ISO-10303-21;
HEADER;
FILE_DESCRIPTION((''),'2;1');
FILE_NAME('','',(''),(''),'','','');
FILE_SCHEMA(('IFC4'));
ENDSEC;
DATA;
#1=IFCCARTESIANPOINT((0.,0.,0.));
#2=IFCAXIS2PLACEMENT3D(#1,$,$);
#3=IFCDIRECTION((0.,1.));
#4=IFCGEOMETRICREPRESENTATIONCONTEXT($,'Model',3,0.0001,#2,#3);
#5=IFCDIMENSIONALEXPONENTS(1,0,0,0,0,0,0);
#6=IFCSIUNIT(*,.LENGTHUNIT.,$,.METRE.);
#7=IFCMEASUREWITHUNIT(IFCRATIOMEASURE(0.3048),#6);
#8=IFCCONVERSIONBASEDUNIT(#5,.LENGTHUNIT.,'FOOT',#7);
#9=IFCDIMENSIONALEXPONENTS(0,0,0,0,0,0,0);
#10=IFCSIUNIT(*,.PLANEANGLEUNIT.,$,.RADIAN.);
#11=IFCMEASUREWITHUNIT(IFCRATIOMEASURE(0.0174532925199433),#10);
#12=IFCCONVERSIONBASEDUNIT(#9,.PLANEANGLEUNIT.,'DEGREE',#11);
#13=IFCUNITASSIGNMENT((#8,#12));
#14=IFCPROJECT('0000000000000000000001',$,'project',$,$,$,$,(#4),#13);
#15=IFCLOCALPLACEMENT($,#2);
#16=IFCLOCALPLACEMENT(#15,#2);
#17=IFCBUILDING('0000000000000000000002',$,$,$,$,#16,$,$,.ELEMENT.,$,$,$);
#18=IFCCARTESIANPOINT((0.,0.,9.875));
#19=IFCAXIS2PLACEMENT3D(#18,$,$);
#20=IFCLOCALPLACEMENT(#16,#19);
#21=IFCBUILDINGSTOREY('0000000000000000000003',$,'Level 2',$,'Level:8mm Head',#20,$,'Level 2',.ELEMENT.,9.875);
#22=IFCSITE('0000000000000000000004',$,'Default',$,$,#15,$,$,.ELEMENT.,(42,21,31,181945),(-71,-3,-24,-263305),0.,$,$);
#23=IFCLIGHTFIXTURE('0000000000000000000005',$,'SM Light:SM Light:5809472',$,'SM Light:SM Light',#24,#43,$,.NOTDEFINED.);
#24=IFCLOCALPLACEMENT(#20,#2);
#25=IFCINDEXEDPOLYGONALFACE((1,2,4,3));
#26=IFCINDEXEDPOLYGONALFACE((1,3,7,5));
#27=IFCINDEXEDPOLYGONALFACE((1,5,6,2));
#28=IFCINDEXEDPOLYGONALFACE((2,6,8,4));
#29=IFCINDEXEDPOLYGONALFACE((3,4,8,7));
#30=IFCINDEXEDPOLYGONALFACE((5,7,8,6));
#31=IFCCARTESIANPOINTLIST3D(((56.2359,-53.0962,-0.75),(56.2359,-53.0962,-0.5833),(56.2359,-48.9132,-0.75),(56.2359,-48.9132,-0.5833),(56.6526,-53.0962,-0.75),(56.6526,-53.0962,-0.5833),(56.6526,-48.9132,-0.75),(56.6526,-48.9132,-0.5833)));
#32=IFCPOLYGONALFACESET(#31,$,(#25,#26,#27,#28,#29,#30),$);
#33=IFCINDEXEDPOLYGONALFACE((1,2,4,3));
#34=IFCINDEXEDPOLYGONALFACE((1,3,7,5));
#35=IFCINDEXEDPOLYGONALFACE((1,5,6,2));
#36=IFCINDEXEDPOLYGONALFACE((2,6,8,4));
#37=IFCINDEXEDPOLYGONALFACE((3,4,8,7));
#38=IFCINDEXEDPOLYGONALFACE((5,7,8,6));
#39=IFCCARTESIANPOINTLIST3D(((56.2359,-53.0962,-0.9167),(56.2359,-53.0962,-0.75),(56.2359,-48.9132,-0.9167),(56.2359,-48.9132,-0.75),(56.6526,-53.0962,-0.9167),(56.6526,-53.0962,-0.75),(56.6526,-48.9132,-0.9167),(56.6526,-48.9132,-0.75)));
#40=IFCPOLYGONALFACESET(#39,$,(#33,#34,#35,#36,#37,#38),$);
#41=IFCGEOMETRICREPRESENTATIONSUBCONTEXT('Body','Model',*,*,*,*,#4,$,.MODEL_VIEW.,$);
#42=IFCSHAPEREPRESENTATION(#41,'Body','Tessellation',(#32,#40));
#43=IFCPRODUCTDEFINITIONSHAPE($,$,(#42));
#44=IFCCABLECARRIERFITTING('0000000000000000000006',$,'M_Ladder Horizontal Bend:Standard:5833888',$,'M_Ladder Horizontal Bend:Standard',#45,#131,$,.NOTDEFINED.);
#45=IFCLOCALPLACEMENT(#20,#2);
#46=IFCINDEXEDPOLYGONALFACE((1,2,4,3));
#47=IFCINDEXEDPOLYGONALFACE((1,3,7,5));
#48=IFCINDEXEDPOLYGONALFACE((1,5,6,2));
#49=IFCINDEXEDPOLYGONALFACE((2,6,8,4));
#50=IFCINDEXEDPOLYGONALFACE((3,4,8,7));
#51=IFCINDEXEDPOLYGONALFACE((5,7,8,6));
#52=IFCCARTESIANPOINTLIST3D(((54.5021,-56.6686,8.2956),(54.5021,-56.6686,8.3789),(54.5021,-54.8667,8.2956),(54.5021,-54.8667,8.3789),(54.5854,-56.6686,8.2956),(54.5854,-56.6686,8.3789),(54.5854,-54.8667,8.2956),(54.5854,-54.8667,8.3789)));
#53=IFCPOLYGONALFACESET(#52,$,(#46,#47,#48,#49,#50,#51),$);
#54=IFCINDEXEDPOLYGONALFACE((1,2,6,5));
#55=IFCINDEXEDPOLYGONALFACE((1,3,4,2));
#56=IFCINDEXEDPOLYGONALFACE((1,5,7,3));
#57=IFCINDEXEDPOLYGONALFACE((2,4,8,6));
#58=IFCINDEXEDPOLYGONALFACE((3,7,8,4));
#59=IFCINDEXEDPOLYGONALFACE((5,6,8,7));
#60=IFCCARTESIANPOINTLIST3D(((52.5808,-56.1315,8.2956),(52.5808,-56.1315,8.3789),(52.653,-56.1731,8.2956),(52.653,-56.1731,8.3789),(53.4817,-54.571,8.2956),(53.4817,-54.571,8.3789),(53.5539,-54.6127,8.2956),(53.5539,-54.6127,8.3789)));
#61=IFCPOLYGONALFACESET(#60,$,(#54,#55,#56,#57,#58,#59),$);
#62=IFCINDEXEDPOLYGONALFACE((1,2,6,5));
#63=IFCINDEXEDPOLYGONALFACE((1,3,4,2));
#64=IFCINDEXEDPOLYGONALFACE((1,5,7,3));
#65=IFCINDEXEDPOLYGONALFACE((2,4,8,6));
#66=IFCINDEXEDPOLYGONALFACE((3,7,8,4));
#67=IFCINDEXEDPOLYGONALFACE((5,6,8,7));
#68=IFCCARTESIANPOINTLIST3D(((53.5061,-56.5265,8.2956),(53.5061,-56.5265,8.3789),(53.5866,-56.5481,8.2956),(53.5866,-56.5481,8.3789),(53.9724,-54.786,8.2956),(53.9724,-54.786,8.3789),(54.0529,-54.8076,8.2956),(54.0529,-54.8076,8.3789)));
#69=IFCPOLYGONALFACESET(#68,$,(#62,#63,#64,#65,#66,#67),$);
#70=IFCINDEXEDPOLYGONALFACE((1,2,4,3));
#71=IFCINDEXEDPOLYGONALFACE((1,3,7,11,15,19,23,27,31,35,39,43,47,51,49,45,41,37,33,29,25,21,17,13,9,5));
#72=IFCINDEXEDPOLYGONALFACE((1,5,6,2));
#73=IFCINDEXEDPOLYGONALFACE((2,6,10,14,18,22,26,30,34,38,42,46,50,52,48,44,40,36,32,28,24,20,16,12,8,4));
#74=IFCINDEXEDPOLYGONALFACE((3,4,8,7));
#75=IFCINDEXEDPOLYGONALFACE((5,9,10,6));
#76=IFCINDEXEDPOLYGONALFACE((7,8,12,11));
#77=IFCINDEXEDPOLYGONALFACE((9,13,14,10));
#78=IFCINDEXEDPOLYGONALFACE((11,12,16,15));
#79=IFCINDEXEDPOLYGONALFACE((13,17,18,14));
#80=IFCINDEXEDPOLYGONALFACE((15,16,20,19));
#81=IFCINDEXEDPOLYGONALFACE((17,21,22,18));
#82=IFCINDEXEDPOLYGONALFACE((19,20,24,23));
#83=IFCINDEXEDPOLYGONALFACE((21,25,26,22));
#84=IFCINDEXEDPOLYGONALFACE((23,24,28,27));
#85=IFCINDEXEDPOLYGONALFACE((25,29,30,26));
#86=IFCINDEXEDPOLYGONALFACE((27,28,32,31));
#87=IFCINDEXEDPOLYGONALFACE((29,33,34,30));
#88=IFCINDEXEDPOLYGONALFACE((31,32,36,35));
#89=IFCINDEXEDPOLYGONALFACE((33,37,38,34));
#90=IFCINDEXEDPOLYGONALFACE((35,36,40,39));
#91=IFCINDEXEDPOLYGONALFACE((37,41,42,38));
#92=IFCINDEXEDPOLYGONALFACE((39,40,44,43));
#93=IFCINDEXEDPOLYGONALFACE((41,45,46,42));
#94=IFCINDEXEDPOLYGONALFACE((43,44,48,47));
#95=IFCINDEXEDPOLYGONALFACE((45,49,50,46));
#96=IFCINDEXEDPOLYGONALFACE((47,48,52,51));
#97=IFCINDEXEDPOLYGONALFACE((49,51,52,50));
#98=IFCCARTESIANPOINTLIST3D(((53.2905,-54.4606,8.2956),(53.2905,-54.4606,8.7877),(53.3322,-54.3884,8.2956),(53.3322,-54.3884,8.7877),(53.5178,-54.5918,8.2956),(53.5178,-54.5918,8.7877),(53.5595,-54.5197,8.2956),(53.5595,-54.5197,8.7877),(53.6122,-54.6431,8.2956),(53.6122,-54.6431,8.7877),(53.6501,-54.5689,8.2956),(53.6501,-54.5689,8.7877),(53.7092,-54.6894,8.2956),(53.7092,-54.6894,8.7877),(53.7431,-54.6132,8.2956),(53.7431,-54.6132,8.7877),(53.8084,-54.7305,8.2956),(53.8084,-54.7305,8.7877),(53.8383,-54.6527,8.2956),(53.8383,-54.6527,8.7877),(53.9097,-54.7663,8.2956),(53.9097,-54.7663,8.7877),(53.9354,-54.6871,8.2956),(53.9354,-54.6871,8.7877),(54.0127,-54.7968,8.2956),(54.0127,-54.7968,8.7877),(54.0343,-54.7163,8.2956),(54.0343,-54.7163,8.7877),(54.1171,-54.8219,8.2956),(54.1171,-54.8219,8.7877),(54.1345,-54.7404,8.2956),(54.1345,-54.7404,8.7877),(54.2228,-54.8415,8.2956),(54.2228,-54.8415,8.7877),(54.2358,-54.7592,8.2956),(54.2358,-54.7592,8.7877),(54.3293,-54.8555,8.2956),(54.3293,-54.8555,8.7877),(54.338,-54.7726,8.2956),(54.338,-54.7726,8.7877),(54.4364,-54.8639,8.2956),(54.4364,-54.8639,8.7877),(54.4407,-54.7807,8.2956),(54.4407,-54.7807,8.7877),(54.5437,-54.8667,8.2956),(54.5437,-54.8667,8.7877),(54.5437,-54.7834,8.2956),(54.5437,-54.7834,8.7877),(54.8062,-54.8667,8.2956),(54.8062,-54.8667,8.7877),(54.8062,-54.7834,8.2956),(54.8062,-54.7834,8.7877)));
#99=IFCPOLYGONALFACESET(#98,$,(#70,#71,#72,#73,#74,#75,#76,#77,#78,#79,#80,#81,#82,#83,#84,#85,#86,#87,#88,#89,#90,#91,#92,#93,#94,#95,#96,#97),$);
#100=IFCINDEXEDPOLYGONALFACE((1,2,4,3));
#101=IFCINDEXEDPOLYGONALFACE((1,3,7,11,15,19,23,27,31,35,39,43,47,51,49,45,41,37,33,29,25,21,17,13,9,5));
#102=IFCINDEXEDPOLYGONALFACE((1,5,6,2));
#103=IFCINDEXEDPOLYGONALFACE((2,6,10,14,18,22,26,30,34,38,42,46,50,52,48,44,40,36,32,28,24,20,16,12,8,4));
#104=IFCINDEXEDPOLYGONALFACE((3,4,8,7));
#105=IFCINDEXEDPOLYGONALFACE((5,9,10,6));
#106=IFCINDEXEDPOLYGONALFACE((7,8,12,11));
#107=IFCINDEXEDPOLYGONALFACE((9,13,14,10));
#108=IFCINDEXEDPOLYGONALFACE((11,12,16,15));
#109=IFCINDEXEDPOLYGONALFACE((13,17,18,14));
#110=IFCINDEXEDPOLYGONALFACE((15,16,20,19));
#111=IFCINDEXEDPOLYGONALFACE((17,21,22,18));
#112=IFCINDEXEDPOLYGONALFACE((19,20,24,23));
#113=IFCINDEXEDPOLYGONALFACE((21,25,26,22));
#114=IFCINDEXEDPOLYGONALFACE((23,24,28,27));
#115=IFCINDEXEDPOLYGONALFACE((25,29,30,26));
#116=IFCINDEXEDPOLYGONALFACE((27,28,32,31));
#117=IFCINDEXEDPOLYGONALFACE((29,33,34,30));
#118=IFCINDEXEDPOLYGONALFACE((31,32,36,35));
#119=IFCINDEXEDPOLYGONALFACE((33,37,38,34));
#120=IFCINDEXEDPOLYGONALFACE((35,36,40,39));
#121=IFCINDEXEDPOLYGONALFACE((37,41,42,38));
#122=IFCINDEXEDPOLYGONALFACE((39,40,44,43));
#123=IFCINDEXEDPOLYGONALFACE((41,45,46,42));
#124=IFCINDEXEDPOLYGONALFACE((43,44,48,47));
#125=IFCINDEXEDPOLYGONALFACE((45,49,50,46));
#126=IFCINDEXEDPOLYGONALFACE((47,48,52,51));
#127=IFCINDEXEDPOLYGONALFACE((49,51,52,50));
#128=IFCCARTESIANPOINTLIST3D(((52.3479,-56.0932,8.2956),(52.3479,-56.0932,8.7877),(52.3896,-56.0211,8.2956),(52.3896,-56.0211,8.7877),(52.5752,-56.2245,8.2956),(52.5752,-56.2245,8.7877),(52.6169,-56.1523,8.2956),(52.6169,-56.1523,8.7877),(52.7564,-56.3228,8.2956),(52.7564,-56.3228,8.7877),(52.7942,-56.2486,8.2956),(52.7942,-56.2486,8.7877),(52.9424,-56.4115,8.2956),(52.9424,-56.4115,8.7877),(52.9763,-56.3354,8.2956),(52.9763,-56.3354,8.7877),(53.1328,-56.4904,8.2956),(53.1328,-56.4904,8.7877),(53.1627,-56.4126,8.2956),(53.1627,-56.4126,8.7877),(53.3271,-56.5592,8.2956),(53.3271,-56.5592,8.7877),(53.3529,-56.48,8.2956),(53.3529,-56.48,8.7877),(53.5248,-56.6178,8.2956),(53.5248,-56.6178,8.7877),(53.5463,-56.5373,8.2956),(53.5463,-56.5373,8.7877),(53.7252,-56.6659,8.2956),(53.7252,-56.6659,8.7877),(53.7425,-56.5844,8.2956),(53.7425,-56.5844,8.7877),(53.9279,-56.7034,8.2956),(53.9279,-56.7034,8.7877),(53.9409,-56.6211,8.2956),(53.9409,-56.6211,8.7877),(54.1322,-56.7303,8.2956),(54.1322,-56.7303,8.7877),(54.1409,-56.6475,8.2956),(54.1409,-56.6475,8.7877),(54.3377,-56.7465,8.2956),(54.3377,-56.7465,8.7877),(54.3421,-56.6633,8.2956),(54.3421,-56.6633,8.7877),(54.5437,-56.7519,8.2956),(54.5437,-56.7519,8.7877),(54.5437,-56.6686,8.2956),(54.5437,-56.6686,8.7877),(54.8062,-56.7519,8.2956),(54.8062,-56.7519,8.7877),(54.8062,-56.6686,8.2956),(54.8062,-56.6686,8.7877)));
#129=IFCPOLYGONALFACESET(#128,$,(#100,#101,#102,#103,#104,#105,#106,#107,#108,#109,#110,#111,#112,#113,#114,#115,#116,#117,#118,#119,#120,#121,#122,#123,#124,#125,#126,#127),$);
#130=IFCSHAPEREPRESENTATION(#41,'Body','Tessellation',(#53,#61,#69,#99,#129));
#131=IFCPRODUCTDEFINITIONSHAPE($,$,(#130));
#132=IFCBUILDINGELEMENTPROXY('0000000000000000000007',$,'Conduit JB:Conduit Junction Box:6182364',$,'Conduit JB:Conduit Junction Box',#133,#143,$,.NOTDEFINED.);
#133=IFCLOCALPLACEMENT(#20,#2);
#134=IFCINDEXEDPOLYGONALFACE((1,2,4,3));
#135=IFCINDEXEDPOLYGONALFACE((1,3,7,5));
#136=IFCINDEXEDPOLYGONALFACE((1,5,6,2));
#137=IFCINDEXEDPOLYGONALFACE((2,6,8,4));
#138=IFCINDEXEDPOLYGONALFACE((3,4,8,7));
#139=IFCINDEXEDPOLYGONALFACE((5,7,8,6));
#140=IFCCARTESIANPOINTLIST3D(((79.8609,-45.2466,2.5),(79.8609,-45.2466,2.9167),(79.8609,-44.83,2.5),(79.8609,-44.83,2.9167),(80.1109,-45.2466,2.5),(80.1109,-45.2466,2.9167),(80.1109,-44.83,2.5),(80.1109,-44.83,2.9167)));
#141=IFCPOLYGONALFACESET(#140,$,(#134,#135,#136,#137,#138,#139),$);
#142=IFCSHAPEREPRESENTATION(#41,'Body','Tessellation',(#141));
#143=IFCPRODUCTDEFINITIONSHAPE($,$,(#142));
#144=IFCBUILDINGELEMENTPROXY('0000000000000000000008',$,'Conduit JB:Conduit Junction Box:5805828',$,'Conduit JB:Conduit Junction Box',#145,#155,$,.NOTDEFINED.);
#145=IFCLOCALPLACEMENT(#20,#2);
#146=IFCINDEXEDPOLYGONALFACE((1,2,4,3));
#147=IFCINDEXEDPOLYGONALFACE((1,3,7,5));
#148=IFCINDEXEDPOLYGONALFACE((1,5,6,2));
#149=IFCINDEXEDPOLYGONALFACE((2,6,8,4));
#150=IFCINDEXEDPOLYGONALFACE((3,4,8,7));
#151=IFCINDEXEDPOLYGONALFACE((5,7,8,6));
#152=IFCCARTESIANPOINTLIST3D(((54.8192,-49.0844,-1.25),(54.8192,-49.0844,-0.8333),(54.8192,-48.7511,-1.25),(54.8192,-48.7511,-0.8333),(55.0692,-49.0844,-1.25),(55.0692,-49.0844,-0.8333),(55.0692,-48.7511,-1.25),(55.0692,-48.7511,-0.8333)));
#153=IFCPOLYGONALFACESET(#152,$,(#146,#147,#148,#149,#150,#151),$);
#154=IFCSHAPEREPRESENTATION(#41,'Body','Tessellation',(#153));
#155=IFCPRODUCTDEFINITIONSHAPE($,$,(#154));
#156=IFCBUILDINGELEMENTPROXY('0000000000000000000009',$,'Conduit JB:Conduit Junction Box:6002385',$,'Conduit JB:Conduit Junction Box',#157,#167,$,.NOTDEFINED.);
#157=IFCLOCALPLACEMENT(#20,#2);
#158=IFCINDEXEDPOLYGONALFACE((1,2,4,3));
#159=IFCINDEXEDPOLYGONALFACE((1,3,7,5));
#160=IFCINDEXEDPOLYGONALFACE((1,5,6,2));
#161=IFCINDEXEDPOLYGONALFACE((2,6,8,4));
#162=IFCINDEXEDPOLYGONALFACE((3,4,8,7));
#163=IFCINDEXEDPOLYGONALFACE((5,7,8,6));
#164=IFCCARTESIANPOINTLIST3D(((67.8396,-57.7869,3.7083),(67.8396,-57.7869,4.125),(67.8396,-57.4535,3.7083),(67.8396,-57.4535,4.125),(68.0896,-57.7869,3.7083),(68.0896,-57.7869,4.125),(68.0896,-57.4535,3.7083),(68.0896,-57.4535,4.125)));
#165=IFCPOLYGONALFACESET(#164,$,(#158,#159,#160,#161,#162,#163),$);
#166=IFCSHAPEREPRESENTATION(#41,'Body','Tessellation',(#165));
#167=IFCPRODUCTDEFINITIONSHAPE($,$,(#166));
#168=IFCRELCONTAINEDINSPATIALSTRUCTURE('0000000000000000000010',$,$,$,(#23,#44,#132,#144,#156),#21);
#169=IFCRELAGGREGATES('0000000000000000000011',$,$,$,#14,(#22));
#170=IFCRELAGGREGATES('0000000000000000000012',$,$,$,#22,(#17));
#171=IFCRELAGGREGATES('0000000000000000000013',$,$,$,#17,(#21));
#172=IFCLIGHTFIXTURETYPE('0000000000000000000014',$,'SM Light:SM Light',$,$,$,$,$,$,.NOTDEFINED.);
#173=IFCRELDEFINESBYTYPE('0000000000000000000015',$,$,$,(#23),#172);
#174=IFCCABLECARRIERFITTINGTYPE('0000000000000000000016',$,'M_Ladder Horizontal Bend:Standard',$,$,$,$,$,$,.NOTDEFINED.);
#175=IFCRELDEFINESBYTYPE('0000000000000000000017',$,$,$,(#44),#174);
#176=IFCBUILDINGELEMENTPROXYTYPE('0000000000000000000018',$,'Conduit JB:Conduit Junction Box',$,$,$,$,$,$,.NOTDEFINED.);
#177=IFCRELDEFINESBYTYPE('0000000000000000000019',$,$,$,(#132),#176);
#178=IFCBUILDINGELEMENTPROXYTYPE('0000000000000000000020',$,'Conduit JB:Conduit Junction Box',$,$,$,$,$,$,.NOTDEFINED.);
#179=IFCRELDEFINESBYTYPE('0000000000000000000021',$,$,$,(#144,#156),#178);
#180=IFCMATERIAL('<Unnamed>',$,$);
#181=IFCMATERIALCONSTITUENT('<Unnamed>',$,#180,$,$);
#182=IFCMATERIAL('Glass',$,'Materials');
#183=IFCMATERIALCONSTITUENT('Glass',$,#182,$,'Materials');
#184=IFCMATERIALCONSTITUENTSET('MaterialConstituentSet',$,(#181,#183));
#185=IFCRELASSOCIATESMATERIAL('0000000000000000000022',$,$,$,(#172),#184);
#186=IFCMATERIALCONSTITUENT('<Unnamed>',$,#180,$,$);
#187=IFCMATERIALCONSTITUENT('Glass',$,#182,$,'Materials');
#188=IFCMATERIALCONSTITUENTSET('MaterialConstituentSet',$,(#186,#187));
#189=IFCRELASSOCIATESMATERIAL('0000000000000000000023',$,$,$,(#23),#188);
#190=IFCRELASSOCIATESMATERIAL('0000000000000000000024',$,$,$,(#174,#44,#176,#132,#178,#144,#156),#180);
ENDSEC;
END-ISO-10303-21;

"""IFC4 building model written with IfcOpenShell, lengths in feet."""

from ifc_helpers import new_model, entity, si_unit, converted_unit, direction, frame, origin, place, context, subcontext, project, spatial, indexed_curve, outline, extrude, source, transform, mapped, material, constituent, constituent_set, type_object, type_shapes, element, save


model = new_model("IFC4")

# Units and contexts
model_context = context("Model", 3, precision=0.0001, world=origin(), true_north=direction((0.0, 1.0)))
body_context = subcontext(model_context, "Body", "Model", "MODEL_VIEW")
ifc_project = project(units=[converted_unit("LENGTHUNIT", "FOOT", entity("IfcRatioMeasure", 0.3048), si_unit("LENGTHUNIT", "METRE"), dimensions=[1, 0, 0, 0, 0, 0, 0]), converted_unit("PLANEANGLEUNIT", "DEGREE", entity("IfcRatioMeasure", 0.0174532925199433), si_unit("PLANEANGLEUNIT", "RADIAN"), dimensions=[0, 0, 0, 0, 0, 0, 0])], contexts=[model_context])

# Site, building, storey
site_placement = place(None, origin())
site = spatial("IfcSite", under=ifc_project, at=site_placement, Name="Default", CompositionType="ELEMENT", RefLatitude=(42, 21, 31, 181945), RefLongitude=(-71, -3, -24, -263305), RefElevation=0.0)
building_placement = place(site_placement, origin())
building = spatial("IfcBuilding", under=site, at=building_placement, CompositionType="ELEMENT")
storey_placement = place(building_placement, frame((0.0, 0.0, 9.875)))
storey = spatial("IfcBuildingStorey", under=building, at=storey_placement, Name="Level 2", ObjectType="Level:8mm Head", LongName="Level 2", CompositionType="ELEMENT", Elevation=9.875)

# Light fixture
ifc_material_1 = material(Name="<Unnamed>")
ifc_material_2 = material(Name="Glass", Category="Materials")
ifc_constituent_1 = constituent(ifc_material_1, Name="<Unnamed>")
ifc_constituent_2 = constituent(ifc_material_2, Name="Glass", Category="Materials")
ifc_constituent_set_1 = constituent_set(constituents=[ifc_constituent_1, ifc_constituent_2], Name="MaterialConstituentSet")
light_fixture_type = type_object("IfcLightFixtureType", Name="SM Light:SM Light", PredefinedType="NOTDEFINED", material=ifc_constituent_set_1)
shared_shape_1 = source(origin(), body_context, "Body", "SweptSolid", [
    extrude(outline(indexed_curve([(-0.2083, -2.0915), (0.2083, -2.0915), (0.2083, 2.0915), (-0.2083, 2.0915), (-0.2083, -2.0915)], self_intersect=False)), frame((-0.0016, -0.2083, 0.1667), z_axis=(0.0, 0.0, 1.0), x_axis=(0.0, 1.0, 0.0)), (0.0, 0.0, 1.0), 0.1667),
    extrude(outline(indexed_curve([(-0.2083, -2.0915), (0.2083, -2.0915), (0.2083, 2.0915), (-0.2083, 2.0915), (-0.2083, -2.0915)], self_intersect=False)), frame((-0.0016, -0.2083, 0.0), z_axis=(0.0, 0.0, 1.0), x_axis=(0.0, 1.0, 0.0)), (0.0, 0.0, 1.0), 0.1667),
])
type_shapes(light_fixture_type, [shared_shape_1])
ifc_constituent_3 = constituent(ifc_material_1, Name="<Unnamed>")
ifc_constituent_4 = constituent(ifc_material_2, Name="Glass", Category="Materials")
ifc_constituent_set_2 = constituent_set(constituents=[ifc_constituent_3, ifc_constituent_4], Name="MaterialConstituentSet")
light_fixture_1_placement = place(storey_placement, frame((56.2359, -51.0031, -0.9167), z_axis=(0.0, 0.0, 1.0), x_axis=(0.0, 1.0, 0.0)))
element("IfcLightFixture", 1, at=light_fixture_1_placement, inside=storey, type_object=light_fixture_type, material=ifc_constituent_set_2, Name="SM Light:SM Light:5809472", ObjectType="SM Light:SM Light", PredefinedType="NOTDEFINED", context=body_context, shape_type="MappedRepresentation", body=[
    mapped(shared_shape_1, transform((0.0, 0.0, 0.0), scale=1.0)),
])

# Cable carrier fitting
cable_carrier_fitting_type_1 = type_object("IfcCableCarrierFittingType", Name="M_Ladder Horizontal Bend:Standard", PredefinedType="NOTDEFINED", material=ifc_material_1)
shared_shape_2 = source(origin(), body_context, "Body", "SweptSolid", [
    extrude(outline(indexed_curve([(-0.9009, -0.0417), (0.9009, -0.0417), (0.9009, 0.0417), (-0.9009, 0.0417), (-0.9009, -0.0417)], self_intersect=False)), frame((0.6852, 0.3956, -0.2461), z_axis=(0.0, 0.0, 1.0), x_axis=(0.5, -0.866025, 0.0)), (0.0, 0.0, 1.0), 0.0833),
    extrude(outline(indexed_curve([(-0.9009, -0.0417), (0.9009, -0.0417), (0.9009, 0.0417), (-0.9009, 0.0417), (-0.9009, -0.0417)], self_intersect=False)), frame((-0.7912, 0.0, -0.2461), z_axis=(0.0, 0.0, 1.0), x_axis=(0.0, -1.0, 0.0)), (0.0, 0.0, 1.0), 0.0833),
    extrude(outline(indexed_curve([(-0.9009, -0.0417), (0.9009, -0.0417), (0.9009, 0.0417), (-0.9009, 0.0417), (-0.9009, -0.0417)], self_intersect=False)), frame((-0.027, 0.1006, -0.2461), z_axis=(0.0, 0.0, 1.0), x_axis=(0.258819, -0.965926, 0.0)), (0.0, 0.0, 1.0), 0.0833),
    extrude(outline(indexed_curve([(-0.7562, -0.2091), (-0.4938, -0.2091), (-0.3864, -0.2063), (-0.2793, -0.1979), (-0.1728, -0.1839), (-0.0672, -0.1643), (0.0373, -0.1392), (0.1403, -0.1087), (0.2416, -0.0728), (0.3408, -0.0317), (0.4378, 0.0145), (0.5322, 0.0658), (0.7595, 0.197), (0.7178, 0.2692), (0.4905, 0.1379), (0.3999, 0.0888), (0.3069, 0.0444), (0.2117, 0.0049), (0.1145, -0.0295), (0.0157, -0.0587), (-0.0845, -0.0828), (-0.1858, -0.1016), (-0.288, -0.115), (-0.3907, -0.1231), (-0.4938, -0.1258), (-0.7562, -0.1258), (-0.7562, -0.2091)], self_intersect=False)), frame((-0.2974, 1.11, -0.2461)), (0.0, 0.0, 1.0), 0.4921),
    extrude(outline(indexed_curve([(-1.2275, -0.3354), (-0.965, -0.3354), (-0.759, -0.33), (-0.5535, -0.3138), (-0.3492, -0.2869), (-0.1465, -0.2494), (0.0539, -0.2013), (0.2516, -0.1427), (0.4459, -0.0739), (0.6363, 0.005), (0.8223, 0.0937), (1.0035, 0.192), (1.2308, 0.3233), (1.1891, 0.3954), (0.9618, 0.2642), (0.7845, 0.1679), (0.6024, 0.0811), (0.416, 0.0039), (0.2258, -0.0635), (0.0324, -0.1208), (-0.1638, -0.1679), (-0.3622, -0.2046), (-0.5622, -0.231), (-0.7634, -0.2468), (-0.965, -0.2521), (-1.2275, -0.2521), (-1.2275, -0.3354)], self_intersect=False)), frame((0.1739, -0.6488, -0.2461)), (0.0, 0.0, 1.0), 0.4921),
])
type_shapes(cable_carrier_fitting_type_1, [shared_shape_2])
cable_carrier_fitting_placement = place(storey_placement, frame((53.7526, -55.7677, 8.5417), z_axis=(0.0, 0.0, 1.0), x_axis=(0.866025, -0.5, 0.0)))
element("IfcCableCarrierFitting", 2, at=cable_carrier_fitting_placement, inside=storey, type_object=cable_carrier_fitting_type_1, material=ifc_material_1, Name="M_Ladder Horizontal Bend:Standard:5833888", ObjectType="M_Ladder Horizontal Bend:Standard", PredefinedType="NOTDEFINED", context=body_context, shape_type="MappedRepresentation", body=[
    mapped(shared_shape_2, transform((0.0, 0.0, 0.0), scale=1.0)),
])

# Building element proxies
building_element_proxy_type_1 = type_object("IfcBuildingElementProxyType", Name="Conduit JB:Conduit Junction Box", PredefinedType="NOTDEFINED", material=ifc_material_1)
shared_shape_3 = source(origin(), body_context, "Body", "SweptSolid", [
    extrude(outline(indexed_curve([(-0.125, -0.2083), (0.125, -0.2083), (0.125, 0.2083), (-0.125, 0.2083), (-0.125, -0.2083)], self_intersect=False)), frame((0.0, -0.125, 0.0), z_axis=(0.0, 0.0, 1.0), x_axis=(0.0, 1.0, 0.0)), (0.0, 0.0, 1.0), 0.4167),
])
type_shapes(building_element_proxy_type_1, [shared_shape_3])
proxy_1_placement = place(storey_placement, frame((80.1109, -45.0383, 2.5), z_axis=(0.0, 0.0, 1.0), x_axis=(0.0, -1.0, 0.0)))
element("IfcBuildingElementProxy", 3, at=proxy_1_placement, inside=storey, type_object=building_element_proxy_type_1, material=ifc_material_1, Name="Conduit JB:Conduit Junction Box:6182364", ObjectType="Conduit JB:Conduit Junction Box", PredefinedType="NOTDEFINED", context=body_context, shape_type="MappedRepresentation", body=[
    mapped(shared_shape_3, transform((0.0, 0.0, 0.0), scale=1.0)),
])
building_element_proxy_type_2 = type_object("IfcBuildingElementProxyType", Name="Conduit JB:Conduit Junction Box", PredefinedType="NOTDEFINED", material=ifc_material_1)
shared_shape_4 = source(origin(), body_context, "Body", "SweptSolid", [
    extrude(outline(indexed_curve([(-0.125, -0.1667), (0.125, -0.1667), (0.125, 0.1667), (-0.125, 0.1667), (-0.125, -0.1667)], self_intersect=False)), frame((0.0, -0.125, 0.0), z_axis=(0.0, 0.0, 1.0), x_axis=(0.0, 1.0, 0.0)), (0.0, 0.0, 1.0), 0.4167),
])
type_shapes(building_element_proxy_type_2, [shared_shape_4])
for number, where, z_axis, x_axis, name in (
    (4, (55.0692, -48.9178, -1.25), (0.0, 0.0, 1.0), (0.0, -1.0, 0.0), "Conduit JB:Conduit Junction Box:5805828"),
    (5, (68.0896, -57.6202, 3.7083), (0.0, 0.0, 1.0), (0.0, -1.0, 0.0), "Conduit JB:Conduit Junction Box:6002385"),
):
    element("IfcBuildingElementProxy", number, at=place(storey_placement, frame(where, z_axis=z_axis, x_axis=x_axis)), inside=storey, type_object=building_element_proxy_type_2, material=ifc_material_1, Name=name, ObjectType="Conduit JB:Conduit Junction Box", PredefinedType="NOTDEFINED", context=body_context, shape_type="MappedRepresentation", body=[
        mapped(shared_shape_4, transform((0.0, 0.0, 0.0), scale=1.0)),
    ])

save(model, "model.ifc")
